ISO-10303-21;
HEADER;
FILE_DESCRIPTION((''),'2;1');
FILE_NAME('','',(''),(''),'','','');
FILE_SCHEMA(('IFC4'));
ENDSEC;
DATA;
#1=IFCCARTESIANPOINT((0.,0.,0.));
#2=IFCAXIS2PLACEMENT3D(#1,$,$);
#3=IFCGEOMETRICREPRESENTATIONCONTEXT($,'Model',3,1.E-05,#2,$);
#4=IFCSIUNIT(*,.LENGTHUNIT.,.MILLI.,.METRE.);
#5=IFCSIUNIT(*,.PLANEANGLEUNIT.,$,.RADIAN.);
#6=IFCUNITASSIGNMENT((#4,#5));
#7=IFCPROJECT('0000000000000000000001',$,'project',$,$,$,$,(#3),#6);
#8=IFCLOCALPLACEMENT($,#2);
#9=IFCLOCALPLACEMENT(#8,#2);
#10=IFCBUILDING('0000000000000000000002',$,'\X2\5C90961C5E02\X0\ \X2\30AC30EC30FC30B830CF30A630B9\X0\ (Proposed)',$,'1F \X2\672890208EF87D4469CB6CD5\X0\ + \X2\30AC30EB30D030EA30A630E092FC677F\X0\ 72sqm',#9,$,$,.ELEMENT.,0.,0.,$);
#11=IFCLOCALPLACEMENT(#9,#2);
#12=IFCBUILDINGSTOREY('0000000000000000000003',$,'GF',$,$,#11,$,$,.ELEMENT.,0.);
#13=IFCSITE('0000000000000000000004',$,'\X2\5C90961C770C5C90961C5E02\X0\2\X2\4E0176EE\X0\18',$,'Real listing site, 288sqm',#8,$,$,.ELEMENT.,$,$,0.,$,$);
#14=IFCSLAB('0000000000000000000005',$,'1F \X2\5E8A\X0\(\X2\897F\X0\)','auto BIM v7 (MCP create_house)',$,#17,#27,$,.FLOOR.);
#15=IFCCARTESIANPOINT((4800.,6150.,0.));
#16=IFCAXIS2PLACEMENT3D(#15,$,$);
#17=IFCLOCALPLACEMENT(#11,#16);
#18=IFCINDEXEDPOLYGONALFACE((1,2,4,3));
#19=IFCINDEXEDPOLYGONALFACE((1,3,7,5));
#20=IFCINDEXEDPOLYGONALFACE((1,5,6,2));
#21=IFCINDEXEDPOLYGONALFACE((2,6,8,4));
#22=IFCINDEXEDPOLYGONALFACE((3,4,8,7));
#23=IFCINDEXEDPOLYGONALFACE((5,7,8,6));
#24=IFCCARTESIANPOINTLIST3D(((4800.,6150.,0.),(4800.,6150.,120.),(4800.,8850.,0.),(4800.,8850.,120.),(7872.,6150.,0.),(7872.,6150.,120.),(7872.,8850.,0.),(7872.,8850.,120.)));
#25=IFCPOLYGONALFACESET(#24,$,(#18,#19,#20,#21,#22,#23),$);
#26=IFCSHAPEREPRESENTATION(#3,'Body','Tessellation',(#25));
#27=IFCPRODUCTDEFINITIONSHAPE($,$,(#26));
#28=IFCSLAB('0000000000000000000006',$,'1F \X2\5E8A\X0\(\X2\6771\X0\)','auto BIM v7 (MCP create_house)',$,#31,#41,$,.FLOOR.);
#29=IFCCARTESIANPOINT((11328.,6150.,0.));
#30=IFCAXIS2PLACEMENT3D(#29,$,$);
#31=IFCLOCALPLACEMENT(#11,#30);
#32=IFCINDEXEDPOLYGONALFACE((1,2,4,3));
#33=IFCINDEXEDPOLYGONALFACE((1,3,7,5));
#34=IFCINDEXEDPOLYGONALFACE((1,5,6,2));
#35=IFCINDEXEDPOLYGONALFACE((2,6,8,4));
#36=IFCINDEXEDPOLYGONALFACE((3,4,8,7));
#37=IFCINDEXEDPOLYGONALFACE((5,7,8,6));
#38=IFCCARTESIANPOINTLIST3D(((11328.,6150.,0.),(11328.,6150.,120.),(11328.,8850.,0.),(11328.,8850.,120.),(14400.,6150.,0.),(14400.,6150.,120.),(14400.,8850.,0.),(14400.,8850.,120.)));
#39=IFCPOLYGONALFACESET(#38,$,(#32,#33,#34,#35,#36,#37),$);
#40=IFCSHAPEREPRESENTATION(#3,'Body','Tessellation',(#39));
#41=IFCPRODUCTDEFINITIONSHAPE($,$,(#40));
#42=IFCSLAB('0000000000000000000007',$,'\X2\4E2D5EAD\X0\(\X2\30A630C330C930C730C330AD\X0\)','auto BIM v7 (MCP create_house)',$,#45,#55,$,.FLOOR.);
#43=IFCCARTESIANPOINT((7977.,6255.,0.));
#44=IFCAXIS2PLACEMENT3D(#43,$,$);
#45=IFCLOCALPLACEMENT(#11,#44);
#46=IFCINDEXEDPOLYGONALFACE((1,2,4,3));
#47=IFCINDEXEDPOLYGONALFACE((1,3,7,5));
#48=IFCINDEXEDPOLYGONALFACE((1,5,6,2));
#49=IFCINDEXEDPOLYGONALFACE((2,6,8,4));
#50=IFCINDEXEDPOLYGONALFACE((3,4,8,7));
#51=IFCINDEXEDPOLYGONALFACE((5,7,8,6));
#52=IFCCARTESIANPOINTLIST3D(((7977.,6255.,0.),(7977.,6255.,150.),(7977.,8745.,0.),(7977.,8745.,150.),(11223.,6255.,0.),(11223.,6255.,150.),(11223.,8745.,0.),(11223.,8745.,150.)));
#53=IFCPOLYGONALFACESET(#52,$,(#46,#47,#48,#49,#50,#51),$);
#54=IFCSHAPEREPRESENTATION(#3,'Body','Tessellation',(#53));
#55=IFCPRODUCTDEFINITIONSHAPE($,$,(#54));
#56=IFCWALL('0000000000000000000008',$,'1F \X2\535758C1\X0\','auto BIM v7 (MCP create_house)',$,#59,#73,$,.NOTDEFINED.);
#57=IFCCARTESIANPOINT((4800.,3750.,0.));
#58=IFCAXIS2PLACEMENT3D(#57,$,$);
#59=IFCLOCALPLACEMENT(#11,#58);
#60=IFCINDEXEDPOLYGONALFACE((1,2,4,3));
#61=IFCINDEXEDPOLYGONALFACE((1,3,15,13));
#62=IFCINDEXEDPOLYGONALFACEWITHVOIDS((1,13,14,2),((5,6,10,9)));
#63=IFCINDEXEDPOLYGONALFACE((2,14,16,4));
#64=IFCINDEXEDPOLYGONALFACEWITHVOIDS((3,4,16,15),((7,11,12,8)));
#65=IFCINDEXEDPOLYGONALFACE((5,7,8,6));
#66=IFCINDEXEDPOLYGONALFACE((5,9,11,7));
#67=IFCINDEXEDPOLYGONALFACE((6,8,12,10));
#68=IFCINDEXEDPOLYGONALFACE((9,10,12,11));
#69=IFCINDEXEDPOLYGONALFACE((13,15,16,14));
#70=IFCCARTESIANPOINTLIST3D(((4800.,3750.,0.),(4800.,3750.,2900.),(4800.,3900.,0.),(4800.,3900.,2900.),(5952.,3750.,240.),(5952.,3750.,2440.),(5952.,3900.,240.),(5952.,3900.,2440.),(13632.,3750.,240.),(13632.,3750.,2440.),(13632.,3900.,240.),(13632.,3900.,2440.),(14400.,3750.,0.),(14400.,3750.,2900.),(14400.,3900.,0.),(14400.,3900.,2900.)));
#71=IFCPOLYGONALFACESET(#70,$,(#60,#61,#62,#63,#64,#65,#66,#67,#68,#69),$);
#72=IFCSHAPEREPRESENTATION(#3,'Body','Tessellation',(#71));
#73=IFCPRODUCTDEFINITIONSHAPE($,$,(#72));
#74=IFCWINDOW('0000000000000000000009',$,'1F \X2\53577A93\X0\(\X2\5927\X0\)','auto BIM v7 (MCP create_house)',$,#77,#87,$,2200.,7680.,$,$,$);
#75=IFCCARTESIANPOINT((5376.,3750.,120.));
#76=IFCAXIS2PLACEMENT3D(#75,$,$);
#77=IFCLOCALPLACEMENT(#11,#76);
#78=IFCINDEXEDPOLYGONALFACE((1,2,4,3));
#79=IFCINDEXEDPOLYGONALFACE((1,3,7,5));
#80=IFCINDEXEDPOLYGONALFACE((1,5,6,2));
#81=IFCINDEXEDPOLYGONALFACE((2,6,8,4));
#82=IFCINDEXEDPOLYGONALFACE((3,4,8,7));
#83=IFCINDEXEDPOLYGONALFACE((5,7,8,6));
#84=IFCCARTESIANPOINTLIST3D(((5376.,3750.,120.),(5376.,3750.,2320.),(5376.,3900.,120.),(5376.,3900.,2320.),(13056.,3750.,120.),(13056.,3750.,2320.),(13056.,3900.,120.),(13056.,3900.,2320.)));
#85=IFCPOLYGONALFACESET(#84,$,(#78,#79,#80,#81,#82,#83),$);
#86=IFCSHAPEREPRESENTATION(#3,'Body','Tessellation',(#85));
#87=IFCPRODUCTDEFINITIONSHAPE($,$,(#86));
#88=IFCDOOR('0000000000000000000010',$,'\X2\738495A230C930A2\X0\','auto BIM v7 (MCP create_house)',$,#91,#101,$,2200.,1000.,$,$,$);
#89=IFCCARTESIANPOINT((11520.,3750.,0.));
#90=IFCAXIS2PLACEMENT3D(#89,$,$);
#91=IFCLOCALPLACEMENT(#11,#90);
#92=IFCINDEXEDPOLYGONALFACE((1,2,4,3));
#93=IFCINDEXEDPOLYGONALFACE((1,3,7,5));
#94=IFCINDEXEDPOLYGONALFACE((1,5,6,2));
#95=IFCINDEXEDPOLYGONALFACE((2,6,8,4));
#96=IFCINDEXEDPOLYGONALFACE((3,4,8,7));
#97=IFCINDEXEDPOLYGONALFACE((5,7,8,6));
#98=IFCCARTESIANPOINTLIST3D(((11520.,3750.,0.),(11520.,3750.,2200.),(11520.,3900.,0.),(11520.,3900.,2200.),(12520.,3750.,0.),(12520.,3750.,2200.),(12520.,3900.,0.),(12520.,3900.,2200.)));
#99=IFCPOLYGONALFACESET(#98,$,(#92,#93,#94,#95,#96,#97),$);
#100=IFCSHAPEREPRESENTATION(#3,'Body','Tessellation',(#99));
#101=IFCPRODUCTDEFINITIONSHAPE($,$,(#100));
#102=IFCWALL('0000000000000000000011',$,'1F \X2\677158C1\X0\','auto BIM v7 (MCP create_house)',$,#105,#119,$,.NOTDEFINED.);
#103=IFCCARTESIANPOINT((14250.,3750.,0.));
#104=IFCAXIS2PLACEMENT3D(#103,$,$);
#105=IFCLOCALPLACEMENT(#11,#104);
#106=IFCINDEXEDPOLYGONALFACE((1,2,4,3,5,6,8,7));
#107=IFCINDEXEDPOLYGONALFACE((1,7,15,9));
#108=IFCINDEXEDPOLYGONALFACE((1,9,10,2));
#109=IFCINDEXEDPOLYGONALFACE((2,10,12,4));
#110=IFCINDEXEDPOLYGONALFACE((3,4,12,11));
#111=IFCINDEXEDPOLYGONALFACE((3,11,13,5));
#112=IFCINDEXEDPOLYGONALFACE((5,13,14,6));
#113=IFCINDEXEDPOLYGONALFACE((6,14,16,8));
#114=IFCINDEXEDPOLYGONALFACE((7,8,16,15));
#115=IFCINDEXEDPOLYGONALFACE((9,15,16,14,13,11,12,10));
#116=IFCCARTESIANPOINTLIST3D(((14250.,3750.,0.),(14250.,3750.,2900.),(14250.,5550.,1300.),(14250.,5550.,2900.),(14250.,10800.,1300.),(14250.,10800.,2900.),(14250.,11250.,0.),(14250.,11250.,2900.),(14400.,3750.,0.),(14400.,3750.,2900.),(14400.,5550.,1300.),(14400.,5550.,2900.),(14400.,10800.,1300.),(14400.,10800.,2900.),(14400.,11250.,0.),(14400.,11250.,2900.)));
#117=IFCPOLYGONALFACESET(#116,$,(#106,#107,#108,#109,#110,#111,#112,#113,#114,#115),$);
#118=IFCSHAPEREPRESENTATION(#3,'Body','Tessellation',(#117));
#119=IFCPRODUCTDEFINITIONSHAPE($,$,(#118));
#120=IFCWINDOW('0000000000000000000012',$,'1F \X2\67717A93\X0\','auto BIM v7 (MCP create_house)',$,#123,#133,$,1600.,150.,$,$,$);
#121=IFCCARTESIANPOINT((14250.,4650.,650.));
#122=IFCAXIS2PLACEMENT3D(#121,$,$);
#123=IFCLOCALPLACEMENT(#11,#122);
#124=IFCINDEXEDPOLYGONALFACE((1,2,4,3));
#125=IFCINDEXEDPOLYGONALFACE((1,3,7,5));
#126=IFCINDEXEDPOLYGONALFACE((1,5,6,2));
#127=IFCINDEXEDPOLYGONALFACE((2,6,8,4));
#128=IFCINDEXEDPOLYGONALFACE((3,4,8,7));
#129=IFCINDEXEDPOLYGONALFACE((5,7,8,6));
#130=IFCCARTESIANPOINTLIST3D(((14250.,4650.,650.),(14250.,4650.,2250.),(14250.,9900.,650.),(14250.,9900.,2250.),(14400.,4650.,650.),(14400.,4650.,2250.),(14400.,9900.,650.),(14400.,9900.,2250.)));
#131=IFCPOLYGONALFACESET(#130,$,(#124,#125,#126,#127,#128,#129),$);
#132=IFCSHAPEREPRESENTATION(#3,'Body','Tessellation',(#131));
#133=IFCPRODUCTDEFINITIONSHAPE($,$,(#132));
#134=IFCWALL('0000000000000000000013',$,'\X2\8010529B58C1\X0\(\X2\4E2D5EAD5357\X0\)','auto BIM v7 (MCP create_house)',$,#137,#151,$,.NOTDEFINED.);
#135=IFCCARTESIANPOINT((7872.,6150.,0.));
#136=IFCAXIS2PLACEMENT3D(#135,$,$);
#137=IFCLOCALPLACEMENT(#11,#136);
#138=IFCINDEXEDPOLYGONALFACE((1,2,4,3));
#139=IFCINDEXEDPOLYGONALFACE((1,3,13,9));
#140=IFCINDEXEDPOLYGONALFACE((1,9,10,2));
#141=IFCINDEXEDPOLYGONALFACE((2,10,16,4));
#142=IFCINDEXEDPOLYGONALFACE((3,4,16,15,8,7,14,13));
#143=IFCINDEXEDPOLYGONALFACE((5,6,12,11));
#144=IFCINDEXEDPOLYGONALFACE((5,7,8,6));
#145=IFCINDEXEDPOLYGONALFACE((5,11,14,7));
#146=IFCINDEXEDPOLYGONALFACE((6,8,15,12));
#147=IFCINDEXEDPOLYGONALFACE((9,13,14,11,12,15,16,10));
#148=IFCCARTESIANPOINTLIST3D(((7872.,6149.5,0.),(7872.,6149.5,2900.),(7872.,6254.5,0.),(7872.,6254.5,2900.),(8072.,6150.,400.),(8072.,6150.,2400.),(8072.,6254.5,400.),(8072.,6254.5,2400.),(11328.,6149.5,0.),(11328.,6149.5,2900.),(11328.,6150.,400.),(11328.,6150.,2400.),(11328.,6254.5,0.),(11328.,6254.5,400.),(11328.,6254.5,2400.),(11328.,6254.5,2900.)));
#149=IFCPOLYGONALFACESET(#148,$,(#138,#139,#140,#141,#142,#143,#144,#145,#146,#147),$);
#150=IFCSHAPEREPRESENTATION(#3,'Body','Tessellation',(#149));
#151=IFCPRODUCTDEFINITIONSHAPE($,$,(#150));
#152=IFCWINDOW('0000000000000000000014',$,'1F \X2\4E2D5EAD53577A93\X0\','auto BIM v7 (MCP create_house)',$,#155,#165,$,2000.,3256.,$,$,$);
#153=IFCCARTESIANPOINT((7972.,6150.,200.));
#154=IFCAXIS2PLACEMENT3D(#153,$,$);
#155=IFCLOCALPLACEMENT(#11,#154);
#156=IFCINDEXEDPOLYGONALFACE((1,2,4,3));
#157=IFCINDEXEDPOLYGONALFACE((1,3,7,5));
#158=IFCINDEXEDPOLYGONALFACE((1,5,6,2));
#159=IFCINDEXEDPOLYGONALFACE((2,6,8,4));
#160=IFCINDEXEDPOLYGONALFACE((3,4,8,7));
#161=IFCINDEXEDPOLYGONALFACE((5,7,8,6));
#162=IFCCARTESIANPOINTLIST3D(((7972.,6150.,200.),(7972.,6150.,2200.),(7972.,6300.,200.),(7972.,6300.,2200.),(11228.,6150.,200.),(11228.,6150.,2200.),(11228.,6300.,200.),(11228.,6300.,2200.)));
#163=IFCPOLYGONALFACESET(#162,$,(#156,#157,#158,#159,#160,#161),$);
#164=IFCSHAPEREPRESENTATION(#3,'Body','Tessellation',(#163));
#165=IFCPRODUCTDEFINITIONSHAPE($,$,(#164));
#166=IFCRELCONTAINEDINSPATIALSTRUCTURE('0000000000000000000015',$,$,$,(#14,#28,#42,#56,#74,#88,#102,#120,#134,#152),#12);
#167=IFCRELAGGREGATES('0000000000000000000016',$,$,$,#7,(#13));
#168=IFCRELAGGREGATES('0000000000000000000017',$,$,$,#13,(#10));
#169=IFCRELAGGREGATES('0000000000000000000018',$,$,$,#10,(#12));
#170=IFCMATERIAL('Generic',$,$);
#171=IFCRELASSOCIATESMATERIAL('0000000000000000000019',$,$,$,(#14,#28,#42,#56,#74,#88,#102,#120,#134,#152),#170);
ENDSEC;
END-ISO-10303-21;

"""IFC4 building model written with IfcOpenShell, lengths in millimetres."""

from ifc_helpers import new_model, si_unit, frame, frame_2d, origin, place, context, project, spatial, rectangle, extrude, material, element, fill, save


model = new_model("IFC4")

# Units and contexts
model_context = context("Model", 3, precision=1e-05, world=origin())
ifc_project = project(units=[si_unit("LENGTHUNIT", "METRE", prefix="MILLI"), si_unit("PLANEANGLEUNIT", "RADIAN")], contexts=[model_context])

# Site, building, storey
site_placement = place(None, origin())
site = spatial("IfcSite", under=ifc_project, at=site_placement, Name="岐阜県岐阜市2丁目18", ObjectType="Real listing site, 288sqm", CompositionType="ELEMENT", RefElevation=0.0)
building_placement = place(site_placement, origin())
building = spatial("IfcBuilding", under=site, at=building_placement, Name="岐阜市 ガレージハウス (Proposed)", ObjectType="1F 木造軸組構法 + ガルバリウム鋼板 72sqm", CompositionType="ELEMENT", ElevationOfRefHeight=0.0, ElevationOfTerrain=0.0)
storey_placement = place(building_placement, origin())
storey = spatial("IfcBuildingStorey", under=building, at=storey_placement, Name="GF", CompositionType="ELEMENT", Elevation=0.0)

# Slabs
ifc_material = material(Name="Generic")
slab_1_placement = place(storey_placement, frame((4800.0, 6150.0, 0.0)))
element("IfcSlab", 1, at=slab_1_placement, inside=storey, material=ifc_material, Name="1F 床(西)", Description="auto BIM v7 (MCP create_house)", PredefinedType="FLOOR", context=model_context, shape_type="SweptSolid", body=[
    extrude(rectangle(XDim=3072.0, YDim=2700.0, at=frame_2d((1536.0, 1350.0))), frame((4800.0, 6150.0, 0.0)), (0.0, 0.0, 1.0), 120.0),
])
slab_2_placement = place(storey_placement, frame((11328.0, 6150.0, 0.0)))
element("IfcSlab", 2, at=slab_2_placement, inside=storey, material=ifc_material, Name="1F 床(東)", Description="auto BIM v7 (MCP create_house)", PredefinedType="FLOOR", context=model_context, shape_type="SweptSolid", body=[
    extrude(rectangle(XDim=3072.0, YDim=2700.0, at=frame_2d((1536.0, 1350.0))), frame((11328.0, 6150.0, 0.0)), (0.0, 0.0, 1.0), 120.0),
])
slab_3_placement = place(storey_placement, frame((7977.0, 6255.0, 0.0)))
element("IfcSlab", 3, at=slab_3_placement, inside=storey, material=ifc_material, Name="中庭(ウッドデッキ)", Description="auto BIM v7 (MCP create_house)", PredefinedType="FLOOR", context=model_context, shape_type="SweptSolid", body=[
    extrude(rectangle(XDim=3246.0, YDim=2490.0, at=frame_2d((1623.0, 1245.0))), frame((7977.0, 6255.0, 0.0)), (0.0, 0.0, 1.0), 150.0),
])

# Wall, openings, window, door
wall_1_placement = place(storey_placement, frame((4800.0, 3750.0, 0.0)))
wall_1 = element("IfcWall", 4, at=wall_1_placement, inside=storey, material=ifc_material, Name="1F 南壁", Description="auto BIM v7 (MCP create_house)", PredefinedType="NOTDEFINED", context=model_context, shape_type="SweptSolid", body=[
    extrude(rectangle(XDim=9600.0, YDim=150.0, at=frame_2d((4800.0, 75.0))), frame((4800.0, 3750.0, 0.0)), (0.0, 0.0, 1.0), 2900.0),
])
opening_1_placement = place(storey_placement, frame((5376.0, 3750.0, 120.0)))
opening_1 = element("IfcOpeningElement", 5, at=opening_1_placement, cuts=wall_1, PredefinedType="NOTDEFINED", context=model_context, shape_type="SweptSolid", body=[
    extrude(rectangle(XDim=7680.0, YDim=150.0, at=frame_2d((3840.0, 75.0))), frame((5376.0, 3750.0, 120.0)), (0.0, 0.0, 1.0), 2200.0),
])
opening_2_placement = place(storey_placement, frame((11520.0, 3750.0, 0.0)))
opening_2 = element("IfcOpeningElement", 6, at=opening_2_placement, cuts=wall_1, PredefinedType="NOTDEFINED", context=model_context, shape_type="SweptSolid", body=[
    extrude(rectangle(XDim=1000.0, YDim=150.0, at=frame_2d((500.0, 75.0))), frame((11520.0, 3750.0, 0.0)), (0.0, 0.0, 1.0), 2200.0),
])
window_1_placement = place(storey_placement, frame((5376.0, 3750.0, 120.0)))
window_1 = element("IfcWindow", 7, at=window_1_placement, inside=storey, material=ifc_material, Name="1F 南窓(大)", Description="auto BIM v7 (MCP create_house)", OverallHeight=2200.0, OverallWidth=7680.0, context=model_context, shape_type="SweptSolid", body=[
    extrude(rectangle(XDim=7680.0, YDim=150.0, at=frame_2d((3840.0, 75.0))), frame((5376.0, 3750.0, 120.0)), (0.0, 0.0, 1.0), 2200.0),
])
fill(opening_1, window_1)
door_placement = place(storey_placement, frame((11520.0, 3750.0, 0.0)))
door = element("IfcDoor", 8, at=door_placement, inside=storey, material=ifc_material, Name="玄関ドア", Description="auto BIM v7 (MCP create_house)", OverallHeight=2200.0, OverallWidth=1000.0, context=model_context, shape_type="SweptSolid", body=[
    extrude(rectangle(XDim=1000.0, YDim=150.0, at=frame_2d((500.0, 75.0))), frame((11520.0, 3750.0, 0.0)), (0.0, 0.0, 1.0), 2200.0),
])
fill(opening_2, door)

# Walls, openings, windows
wall_2_placement = place(storey_placement, frame((14250.0, 3750.0, 0.0)))
wall_2 = element("IfcWall", 9, at=wall_2_placement, inside=storey, material=ifc_material, Name="1F 東壁", Description="auto BIM v7 (MCP create_house)", PredefinedType="NOTDEFINED", context=model_context, shape_type="SweptSolid", body=[
    extrude(rectangle(XDim=150.0, YDim=7500.0, at=frame_2d((75.0, 3750.0))), frame((14250.0, 3750.0, 0.0)), (0.0, 0.0, 1.0), 2900.0),
])
opening_3_placement = place(storey_placement, frame((14250.0, 4650.0, 650.0)))
opening_3 = element("IfcOpeningElement", 10, at=opening_3_placement, cuts=wall_2, PredefinedType="NOTDEFINED", context=model_context, shape_type="SweptSolid", body=[
    extrude(rectangle(XDim=150.0, YDim=5250.0, at=frame_2d((75.0, 2625.0))), frame((14250.0, 4650.0, 650.0)), (0.0, 0.0, 1.0), 1600.0),
])
window_2_placement = place(storey_placement, frame((14250.0, 4650.0, 650.0)))
window_2 = element("IfcWindow", 11, at=window_2_placement, inside=storey, material=ifc_material, Name="1F 東窓", Description="auto BIM v7 (MCP create_house)", OverallHeight=1600.0, OverallWidth=150.0, context=model_context, shape_type="SweptSolid", body=[
    extrude(rectangle(XDim=150.0, YDim=5250.0, at=frame_2d((75.0, 2625.0))), frame((14250.0, 4650.0, 650.0)), (0.0, 0.0, 1.0), 1600.0),
])
fill(opening_3, window_2)
wall_3_placement = place(storey_placement, frame((7872.0, 6150.0, 0.0)))
wall_3 = element("IfcWall", 12, at=wall_3_placement, inside=storey, material=ifc_material, Name="耐力壁(中庭南)", Description="auto BIM v7 (MCP create_house)", PredefinedType="NOTDEFINED", context=model_context, shape_type="SweptSolid", body=[
    extrude(rectangle(XDim=3456.0, YDim=105.0, at=frame_2d((1728.0, 52.0))), frame((7872.0, 6150.0, 0.0)), (0.0, 0.0, 1.0), 2900.0),
])
opening_4_placement = place(storey_placement, frame((7972.0, 6150.0, 200.0)))
opening_4 = element("IfcOpeningElement", 13, at=opening_4_placement, cuts=wall_3, PredefinedType="NOTDEFINED", context=model_context, shape_type="SweptSolid", body=[
    extrude(rectangle(XDim=3256.0, YDim=150.0, at=frame_2d((1628.0, 75.0))), frame((7972.0, 6150.0, 200.0)), (0.0, 0.0, 1.0), 2000.0),
])
window_3_placement = place(storey_placement, frame((7972.0, 6150.0, 200.0)))
window_3 = element("IfcWindow", 14, at=window_3_placement, inside=storey, material=ifc_material, Name="1F 中庭南窓", Description="auto BIM v7 (MCP create_house)", OverallHeight=2000.0, OverallWidth=3256.0, context=model_context, shape_type="SweptSolid", body=[
    extrude(rectangle(XDim=3256.0, YDim=150.0, at=frame_2d((1628.0, 75.0))), frame((7972.0, 6150.0, 200.0)), (0.0, 0.0, 1.0), 2000.0),
])
fill(opening_4, window_3)

save(model, "model.ifc")
